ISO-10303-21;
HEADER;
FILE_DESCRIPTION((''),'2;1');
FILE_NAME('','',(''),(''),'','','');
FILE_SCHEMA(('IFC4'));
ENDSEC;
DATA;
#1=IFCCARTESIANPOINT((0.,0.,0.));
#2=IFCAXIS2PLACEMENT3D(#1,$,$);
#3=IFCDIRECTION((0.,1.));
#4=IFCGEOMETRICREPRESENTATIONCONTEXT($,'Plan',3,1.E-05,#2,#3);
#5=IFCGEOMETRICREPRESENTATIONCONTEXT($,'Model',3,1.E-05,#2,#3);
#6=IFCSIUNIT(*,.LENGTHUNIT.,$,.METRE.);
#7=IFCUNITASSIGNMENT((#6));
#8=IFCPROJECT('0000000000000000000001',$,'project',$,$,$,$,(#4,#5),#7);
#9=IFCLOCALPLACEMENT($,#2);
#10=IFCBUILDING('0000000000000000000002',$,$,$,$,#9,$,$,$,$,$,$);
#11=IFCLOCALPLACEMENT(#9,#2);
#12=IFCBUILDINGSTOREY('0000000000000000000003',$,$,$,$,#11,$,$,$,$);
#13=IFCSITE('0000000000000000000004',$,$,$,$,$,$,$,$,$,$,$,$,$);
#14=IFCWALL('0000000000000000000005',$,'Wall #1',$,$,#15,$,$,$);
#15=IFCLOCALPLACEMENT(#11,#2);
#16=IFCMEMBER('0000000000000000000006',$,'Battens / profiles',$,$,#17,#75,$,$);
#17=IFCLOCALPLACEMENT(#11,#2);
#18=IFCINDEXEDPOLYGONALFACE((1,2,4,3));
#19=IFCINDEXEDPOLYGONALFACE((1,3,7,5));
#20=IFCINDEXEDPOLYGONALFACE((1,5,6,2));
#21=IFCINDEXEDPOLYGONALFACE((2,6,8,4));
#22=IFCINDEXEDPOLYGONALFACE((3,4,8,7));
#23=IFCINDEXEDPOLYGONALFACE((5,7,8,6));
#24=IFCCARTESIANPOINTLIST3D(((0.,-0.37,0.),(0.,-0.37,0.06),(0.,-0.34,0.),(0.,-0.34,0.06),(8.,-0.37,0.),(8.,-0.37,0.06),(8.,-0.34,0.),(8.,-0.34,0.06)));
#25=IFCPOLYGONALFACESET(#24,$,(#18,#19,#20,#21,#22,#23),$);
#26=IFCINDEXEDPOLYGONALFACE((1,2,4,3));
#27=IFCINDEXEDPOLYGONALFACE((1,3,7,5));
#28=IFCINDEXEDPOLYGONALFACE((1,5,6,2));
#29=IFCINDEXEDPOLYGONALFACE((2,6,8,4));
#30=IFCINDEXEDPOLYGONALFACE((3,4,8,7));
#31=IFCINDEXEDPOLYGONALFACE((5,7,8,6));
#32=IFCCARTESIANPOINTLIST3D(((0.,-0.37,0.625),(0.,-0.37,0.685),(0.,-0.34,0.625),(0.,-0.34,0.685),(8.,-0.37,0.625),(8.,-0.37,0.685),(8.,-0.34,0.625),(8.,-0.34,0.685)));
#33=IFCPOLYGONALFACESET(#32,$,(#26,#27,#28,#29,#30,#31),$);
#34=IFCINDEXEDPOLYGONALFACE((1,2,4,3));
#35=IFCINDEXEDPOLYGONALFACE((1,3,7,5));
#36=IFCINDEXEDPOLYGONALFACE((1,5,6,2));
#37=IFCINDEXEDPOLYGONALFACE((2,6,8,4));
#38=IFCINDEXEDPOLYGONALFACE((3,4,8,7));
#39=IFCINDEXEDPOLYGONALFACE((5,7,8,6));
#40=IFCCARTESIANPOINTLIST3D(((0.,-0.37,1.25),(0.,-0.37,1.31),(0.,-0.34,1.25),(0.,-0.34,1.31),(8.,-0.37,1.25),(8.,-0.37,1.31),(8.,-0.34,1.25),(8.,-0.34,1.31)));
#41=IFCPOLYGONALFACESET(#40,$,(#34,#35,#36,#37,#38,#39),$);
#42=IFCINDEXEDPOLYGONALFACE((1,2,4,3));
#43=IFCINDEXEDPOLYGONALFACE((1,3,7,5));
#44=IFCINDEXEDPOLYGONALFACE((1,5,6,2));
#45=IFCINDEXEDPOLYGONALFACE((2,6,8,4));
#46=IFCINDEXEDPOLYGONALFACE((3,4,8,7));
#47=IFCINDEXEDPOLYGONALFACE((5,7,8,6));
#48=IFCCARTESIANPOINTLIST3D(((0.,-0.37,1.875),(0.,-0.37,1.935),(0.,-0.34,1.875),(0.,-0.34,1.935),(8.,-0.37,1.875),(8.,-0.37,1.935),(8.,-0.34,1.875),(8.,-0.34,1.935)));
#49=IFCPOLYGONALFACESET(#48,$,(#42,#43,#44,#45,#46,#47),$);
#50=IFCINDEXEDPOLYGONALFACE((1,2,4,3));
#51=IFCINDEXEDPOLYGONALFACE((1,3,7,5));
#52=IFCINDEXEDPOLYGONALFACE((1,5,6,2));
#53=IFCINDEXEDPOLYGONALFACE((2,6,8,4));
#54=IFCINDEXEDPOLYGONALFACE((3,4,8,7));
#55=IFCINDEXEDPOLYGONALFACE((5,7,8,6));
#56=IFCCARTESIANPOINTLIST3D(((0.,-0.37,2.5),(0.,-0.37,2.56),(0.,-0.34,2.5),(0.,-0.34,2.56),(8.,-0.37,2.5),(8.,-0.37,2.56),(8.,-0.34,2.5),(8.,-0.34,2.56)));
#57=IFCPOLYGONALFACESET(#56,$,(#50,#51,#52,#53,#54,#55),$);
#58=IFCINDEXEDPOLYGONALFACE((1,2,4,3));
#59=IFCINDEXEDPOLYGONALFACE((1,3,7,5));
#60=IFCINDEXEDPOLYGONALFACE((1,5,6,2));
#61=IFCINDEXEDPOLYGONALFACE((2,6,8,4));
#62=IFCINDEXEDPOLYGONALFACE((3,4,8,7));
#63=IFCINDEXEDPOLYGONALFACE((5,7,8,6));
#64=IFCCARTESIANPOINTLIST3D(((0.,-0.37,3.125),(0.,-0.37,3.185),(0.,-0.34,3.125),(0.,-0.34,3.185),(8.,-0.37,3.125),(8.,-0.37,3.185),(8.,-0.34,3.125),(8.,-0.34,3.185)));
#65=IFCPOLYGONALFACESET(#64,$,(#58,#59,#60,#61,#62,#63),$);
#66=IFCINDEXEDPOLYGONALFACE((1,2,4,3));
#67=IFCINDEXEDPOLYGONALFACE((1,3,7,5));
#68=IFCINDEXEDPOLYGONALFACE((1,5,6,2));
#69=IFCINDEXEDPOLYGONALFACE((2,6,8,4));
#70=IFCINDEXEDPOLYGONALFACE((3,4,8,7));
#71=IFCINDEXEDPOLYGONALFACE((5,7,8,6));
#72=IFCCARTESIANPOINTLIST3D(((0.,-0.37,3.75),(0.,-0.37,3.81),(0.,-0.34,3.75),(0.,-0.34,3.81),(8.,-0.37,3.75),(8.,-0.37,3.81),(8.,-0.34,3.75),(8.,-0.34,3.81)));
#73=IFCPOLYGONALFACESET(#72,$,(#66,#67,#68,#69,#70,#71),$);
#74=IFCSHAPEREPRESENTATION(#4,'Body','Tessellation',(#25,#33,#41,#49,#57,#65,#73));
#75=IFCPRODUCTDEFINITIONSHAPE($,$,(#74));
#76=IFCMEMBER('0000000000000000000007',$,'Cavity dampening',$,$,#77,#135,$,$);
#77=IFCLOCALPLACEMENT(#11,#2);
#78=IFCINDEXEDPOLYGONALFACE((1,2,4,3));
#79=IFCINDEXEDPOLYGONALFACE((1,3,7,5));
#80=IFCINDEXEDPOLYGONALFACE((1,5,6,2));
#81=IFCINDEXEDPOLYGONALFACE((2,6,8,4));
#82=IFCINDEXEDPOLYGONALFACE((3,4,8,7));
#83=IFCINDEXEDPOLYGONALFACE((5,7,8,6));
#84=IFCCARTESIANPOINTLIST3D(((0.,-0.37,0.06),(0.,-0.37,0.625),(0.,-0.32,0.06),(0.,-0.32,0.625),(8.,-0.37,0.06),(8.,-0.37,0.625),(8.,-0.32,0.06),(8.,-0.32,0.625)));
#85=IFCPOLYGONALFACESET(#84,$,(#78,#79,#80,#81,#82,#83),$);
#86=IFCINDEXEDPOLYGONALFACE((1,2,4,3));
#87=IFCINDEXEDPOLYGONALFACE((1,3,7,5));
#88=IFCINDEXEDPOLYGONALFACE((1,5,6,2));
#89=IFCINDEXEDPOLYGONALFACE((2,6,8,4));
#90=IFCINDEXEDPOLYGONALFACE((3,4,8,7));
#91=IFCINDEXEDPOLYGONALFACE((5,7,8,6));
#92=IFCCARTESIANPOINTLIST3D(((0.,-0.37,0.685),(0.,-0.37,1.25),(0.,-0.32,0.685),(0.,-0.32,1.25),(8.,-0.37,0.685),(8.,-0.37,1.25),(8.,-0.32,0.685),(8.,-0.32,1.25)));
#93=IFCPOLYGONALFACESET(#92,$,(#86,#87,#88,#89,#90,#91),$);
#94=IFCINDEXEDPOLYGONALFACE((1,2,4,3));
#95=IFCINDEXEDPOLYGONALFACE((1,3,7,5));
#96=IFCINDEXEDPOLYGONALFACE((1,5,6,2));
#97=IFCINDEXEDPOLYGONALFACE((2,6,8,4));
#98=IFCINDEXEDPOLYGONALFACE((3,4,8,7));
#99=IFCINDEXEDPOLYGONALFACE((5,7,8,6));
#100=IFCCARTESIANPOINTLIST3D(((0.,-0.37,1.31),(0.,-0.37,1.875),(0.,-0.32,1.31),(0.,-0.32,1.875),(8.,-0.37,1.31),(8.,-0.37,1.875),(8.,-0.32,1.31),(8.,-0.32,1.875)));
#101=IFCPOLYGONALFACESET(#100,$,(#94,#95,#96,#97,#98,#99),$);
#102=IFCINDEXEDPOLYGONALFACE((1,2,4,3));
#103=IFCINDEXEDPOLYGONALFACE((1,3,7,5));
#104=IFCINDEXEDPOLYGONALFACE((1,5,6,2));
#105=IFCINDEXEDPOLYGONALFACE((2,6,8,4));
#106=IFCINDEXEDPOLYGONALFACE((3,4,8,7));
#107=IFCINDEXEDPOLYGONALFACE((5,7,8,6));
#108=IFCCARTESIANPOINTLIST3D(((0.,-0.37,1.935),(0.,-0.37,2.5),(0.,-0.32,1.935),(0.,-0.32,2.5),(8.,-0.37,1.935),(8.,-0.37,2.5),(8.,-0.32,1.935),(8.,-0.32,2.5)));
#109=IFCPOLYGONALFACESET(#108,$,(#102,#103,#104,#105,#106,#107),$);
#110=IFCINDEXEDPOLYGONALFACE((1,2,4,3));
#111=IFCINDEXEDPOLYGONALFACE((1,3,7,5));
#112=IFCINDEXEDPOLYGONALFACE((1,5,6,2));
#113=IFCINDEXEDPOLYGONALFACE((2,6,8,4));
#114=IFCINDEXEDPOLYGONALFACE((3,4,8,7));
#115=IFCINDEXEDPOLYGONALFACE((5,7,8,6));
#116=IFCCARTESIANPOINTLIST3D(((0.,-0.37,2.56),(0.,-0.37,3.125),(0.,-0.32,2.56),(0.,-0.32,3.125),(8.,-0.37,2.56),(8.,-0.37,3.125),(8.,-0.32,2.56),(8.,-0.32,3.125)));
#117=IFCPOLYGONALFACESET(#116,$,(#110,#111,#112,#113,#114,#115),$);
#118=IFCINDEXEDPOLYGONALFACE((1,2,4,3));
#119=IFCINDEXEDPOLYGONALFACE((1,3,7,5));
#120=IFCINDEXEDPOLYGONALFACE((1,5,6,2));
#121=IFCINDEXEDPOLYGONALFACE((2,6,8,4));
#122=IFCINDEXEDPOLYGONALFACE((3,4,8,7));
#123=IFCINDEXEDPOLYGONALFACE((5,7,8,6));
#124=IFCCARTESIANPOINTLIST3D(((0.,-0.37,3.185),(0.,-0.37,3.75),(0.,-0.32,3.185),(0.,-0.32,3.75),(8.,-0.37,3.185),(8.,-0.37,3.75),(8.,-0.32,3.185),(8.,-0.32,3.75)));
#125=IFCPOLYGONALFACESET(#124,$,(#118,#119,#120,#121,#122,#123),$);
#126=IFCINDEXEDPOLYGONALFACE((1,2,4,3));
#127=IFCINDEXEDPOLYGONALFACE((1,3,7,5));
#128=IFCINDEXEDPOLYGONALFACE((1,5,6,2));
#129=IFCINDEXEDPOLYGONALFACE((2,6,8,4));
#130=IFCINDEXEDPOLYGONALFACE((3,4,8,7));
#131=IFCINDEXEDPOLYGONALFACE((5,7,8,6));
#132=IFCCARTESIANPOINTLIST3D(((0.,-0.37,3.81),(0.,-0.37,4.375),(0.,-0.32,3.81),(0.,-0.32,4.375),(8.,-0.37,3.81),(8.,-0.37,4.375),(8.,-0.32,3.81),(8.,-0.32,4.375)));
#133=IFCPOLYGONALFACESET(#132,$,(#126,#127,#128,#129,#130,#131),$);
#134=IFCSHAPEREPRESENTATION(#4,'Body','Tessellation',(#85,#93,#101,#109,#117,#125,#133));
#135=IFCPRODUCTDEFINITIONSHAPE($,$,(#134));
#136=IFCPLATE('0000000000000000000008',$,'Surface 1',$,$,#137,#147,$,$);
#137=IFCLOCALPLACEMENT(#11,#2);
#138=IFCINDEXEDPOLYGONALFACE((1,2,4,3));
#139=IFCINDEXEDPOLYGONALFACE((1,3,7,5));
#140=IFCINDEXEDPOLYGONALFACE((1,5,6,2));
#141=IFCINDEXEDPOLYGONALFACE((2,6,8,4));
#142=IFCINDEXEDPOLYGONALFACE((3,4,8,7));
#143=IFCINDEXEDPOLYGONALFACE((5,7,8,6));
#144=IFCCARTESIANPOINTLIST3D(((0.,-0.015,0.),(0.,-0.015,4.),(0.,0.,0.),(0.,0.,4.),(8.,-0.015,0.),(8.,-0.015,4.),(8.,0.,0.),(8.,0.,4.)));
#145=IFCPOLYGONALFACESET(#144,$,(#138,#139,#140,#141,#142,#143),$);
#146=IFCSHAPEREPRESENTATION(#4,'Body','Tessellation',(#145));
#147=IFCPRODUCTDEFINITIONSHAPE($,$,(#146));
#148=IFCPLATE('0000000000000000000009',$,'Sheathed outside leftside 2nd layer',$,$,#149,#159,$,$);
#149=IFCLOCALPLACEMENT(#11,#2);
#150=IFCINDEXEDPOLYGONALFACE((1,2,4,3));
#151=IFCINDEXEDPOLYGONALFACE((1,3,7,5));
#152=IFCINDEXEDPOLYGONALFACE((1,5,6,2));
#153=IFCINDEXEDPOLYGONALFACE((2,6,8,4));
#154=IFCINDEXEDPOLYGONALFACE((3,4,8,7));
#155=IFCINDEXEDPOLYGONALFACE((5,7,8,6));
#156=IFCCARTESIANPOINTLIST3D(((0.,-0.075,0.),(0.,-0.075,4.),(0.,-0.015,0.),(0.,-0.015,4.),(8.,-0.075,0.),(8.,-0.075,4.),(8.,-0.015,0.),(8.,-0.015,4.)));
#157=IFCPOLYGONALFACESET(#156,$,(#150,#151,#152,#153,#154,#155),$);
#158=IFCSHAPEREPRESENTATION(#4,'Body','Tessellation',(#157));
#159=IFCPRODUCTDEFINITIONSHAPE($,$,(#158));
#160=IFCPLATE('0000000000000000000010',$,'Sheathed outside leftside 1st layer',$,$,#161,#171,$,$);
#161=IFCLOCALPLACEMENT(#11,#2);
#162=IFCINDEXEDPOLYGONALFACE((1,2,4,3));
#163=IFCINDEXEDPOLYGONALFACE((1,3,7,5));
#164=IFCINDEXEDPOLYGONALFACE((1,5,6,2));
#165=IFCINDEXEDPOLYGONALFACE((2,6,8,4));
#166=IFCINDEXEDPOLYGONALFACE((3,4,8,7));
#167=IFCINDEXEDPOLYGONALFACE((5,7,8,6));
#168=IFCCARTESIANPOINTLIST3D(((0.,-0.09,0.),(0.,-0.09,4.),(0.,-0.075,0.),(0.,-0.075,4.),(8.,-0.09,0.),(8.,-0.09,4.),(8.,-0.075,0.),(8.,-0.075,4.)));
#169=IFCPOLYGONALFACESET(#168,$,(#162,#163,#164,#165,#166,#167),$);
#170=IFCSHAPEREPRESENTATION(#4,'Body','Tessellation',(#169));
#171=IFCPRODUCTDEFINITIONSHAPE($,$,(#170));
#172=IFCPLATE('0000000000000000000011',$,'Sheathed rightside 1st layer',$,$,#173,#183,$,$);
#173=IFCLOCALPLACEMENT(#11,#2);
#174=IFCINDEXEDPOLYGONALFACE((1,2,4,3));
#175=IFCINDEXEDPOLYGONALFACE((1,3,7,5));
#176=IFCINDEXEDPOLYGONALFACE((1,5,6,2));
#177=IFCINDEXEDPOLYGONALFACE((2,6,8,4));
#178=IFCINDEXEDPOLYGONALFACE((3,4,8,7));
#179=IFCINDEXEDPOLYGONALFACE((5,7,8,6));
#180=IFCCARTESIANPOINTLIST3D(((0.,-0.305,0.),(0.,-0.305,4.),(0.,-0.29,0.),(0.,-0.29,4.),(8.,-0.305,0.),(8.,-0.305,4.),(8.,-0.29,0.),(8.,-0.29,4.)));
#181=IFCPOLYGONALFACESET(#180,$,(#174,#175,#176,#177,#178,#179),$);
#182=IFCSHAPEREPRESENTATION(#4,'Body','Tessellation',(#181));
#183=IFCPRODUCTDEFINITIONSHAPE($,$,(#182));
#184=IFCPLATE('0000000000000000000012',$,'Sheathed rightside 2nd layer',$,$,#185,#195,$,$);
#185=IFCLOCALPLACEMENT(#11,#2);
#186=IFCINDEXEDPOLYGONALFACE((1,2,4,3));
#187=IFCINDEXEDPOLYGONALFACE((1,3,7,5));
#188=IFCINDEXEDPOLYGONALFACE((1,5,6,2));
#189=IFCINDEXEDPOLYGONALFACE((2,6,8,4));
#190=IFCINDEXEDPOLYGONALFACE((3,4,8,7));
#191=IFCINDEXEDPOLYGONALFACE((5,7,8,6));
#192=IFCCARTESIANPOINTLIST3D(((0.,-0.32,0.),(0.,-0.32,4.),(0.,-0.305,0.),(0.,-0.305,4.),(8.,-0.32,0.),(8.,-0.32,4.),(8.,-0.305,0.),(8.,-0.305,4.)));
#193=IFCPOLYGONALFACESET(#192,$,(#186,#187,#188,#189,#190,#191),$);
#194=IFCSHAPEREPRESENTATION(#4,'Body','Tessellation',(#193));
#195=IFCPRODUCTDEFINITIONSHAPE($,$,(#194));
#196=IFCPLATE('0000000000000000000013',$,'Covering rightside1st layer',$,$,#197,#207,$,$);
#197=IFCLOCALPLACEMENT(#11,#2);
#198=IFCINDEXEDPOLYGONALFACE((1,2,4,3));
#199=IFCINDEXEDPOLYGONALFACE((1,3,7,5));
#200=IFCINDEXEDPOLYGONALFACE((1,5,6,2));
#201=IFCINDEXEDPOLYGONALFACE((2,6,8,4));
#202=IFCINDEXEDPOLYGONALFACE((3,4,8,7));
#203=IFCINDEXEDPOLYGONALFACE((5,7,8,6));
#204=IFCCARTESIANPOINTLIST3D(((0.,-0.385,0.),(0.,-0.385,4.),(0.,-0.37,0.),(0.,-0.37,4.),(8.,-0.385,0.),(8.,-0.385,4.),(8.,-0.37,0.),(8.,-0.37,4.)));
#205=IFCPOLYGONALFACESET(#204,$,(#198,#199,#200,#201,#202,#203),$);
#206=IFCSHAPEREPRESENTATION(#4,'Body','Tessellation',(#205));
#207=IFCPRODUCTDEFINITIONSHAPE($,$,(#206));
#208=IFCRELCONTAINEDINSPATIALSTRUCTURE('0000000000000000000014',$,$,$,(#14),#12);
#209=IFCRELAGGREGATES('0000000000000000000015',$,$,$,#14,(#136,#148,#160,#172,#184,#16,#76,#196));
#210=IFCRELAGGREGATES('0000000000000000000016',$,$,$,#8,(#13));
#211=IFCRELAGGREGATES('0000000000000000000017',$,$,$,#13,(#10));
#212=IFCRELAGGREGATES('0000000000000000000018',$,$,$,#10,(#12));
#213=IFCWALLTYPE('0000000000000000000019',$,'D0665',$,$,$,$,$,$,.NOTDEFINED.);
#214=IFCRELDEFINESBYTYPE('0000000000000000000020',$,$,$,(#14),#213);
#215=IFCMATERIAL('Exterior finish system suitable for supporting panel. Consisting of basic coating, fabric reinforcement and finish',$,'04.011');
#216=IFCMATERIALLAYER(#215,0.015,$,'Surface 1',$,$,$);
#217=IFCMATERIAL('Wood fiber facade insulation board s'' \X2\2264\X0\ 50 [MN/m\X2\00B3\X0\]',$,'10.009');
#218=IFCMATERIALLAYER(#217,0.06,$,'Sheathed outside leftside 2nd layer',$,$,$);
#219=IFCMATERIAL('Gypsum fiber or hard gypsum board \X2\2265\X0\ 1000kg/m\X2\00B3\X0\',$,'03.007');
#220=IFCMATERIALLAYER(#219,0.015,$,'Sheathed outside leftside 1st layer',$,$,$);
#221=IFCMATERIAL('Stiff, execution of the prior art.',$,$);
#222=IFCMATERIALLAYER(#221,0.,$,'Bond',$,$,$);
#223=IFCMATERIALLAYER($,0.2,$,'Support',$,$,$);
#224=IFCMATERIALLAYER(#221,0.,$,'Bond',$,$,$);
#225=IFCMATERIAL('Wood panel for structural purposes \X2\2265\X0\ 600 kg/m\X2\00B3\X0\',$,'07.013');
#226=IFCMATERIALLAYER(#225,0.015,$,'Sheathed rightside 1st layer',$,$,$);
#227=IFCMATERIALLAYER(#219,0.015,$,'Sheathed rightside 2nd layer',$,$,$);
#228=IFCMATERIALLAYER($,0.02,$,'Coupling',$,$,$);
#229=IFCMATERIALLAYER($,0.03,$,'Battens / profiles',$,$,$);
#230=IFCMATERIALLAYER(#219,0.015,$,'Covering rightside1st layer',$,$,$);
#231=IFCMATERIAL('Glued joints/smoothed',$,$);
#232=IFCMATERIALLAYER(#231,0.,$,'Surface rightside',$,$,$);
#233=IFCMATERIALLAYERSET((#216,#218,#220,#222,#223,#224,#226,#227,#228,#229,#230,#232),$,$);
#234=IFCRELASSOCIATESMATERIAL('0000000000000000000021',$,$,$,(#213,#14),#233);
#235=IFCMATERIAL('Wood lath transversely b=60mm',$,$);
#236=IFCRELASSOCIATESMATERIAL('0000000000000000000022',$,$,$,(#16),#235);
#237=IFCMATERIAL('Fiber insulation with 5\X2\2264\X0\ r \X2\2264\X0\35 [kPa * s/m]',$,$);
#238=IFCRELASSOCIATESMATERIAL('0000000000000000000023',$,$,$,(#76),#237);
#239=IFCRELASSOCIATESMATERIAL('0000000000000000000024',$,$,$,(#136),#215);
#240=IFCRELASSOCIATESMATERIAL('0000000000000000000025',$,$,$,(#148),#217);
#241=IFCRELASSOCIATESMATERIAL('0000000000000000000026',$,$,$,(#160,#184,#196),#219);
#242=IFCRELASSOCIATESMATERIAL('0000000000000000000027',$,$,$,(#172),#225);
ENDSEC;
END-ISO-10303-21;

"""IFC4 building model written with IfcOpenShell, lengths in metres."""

from ifc_helpers import new_model, si_unit, direction, frame, frame_2d, origin, origin_with_axes, place, context, project, spatial, rectangle, extrude, material, layer, layer_set, type_object, element, aggregate, save


model = new_model("IFC4")

# Units and contexts
plan_context = context("Plan", 3, precision=1e-05, world=origin(), true_north=direction((0.0, 1.0)))
model_context = context("Model", 3, precision=1e-05, world=origin(), true_north=direction((0.0, 1.0)))
ifc_project = project(units=[si_unit("LENGTHUNIT", "METRE")], contexts=[plan_context, model_context])

# Site, building, storey
site = spatial("IfcSite", under=ifc_project)
building_placement = place(None, origin())
building = spatial("IfcBuilding", under=site, at=building_placement)
storey_placement = place(building_placement, origin())
storey = spatial("IfcBuildingStorey", under=building, at=storey_placement)

# Wall, members, plates
ifc_material_1 = material(Name="Exterior finish system suitable for supporting panel. Consisting of basic coating, fabric reinforcement and finish", Category="04.011")
ifc_layer_1 = layer(ifc_material_1, 0.015, Name="Surface 1")
ifc_material_2 = material(Name="Wood fiber facade insulation board s' ≤ 50 [MN/m³]", Category="10.009")
ifc_layer_2 = layer(ifc_material_2, 0.06, Name="Sheathed outside leftside 2nd layer")
ifc_material_3 = material(Name="Gypsum fiber or hard gypsum board ≥ 1000kg/m³", Category="03.007")
ifc_layer_3 = layer(ifc_material_3, 0.015, Name="Sheathed outside leftside 1st layer")
ifc_material_4 = material(Name="Stiff, execution of the prior art.")
ifc_layer_4 = layer(ifc_material_4, 0.0, Name="Bond")
ifc_layer_5 = layer(None, 0.2, Name="Support")
ifc_layer_6 = layer(ifc_material_4, 0.0, Name="Bond")
ifc_material_5 = material(Name="Wood panel for structural purposes ≥ 600 kg/m³", Category="07.013")
ifc_layer_7 = layer(ifc_material_5, 0.015, Name="Sheathed rightside 1st layer")
ifc_layer_8 = layer(ifc_material_3, 0.015, Name="Sheathed rightside 2nd layer")
ifc_layer_9 = layer(None, 0.02, Name="Coupling")
ifc_layer_10 = layer(None, 0.03, Name="Battens / profiles")
ifc_layer_11 = layer(ifc_material_3, 0.015, Name="Covering rightside1st layer")
ifc_material_6 = material(Name="Glued joints/smoothed")
ifc_layer_12 = layer(ifc_material_6, 0.0, Name="Surface rightside")
ifc_layer_set = layer_set([ifc_layer_1, ifc_layer_2, ifc_layer_3, ifc_layer_4, ifc_layer_5, ifc_layer_6, ifc_layer_7, ifc_layer_8, ifc_layer_9, ifc_layer_10, ifc_layer_11, ifc_layer_12])
wall_type = type_object("IfcWallType", Name="D0665", PredefinedType="NOTDEFINED", material=ifc_layer_set)
wall_placement = place(None, frame((0.0, 0.0, 0.0), z_axis=(0.0, -1.0, 0.0), x_axis=(1.0, 0.0, 0.0)))
wall = element("IfcWall", 1, at=wall_placement, inside=storey, type_object=wall_type, material=ifc_layer_set, Name="Wall #1")
ifc_material_7 = material(Name="Fiber insulation with 5≤ r ≤35 [kPa * s/m]")
ifc_material_8 = material(Name="Wood lath transversely b=60mm")
member_1_placement = place(wall_placement, origin())
member_1 = element("IfcMember", 2, at=member_1_placement, material=ifc_material_8, Name="Battens / profiles", context=plan_context, shape_type="SweptSolid", body=[
    extrude(rectangle(XDim=0.06, YDim=0.03, at=frame_2d((0.03, 0.015), x_axis=(1.0, 0.0))), frame((0.0, 0.0, 0.34), z_axis=(1.0, 0.0, 0.0), x_axis=(0.0, 1.0, 0.0)), (0.0, 0.0, 1.0), 8.0),
    extrude(rectangle(XDim=0.06, YDim=0.03, at=frame_2d((0.03, 0.015), x_axis=(1.0, 0.0))), frame((0.0, 0.625, 0.34), z_axis=(1.0, 0.0, 0.0), x_axis=(0.0, 1.0, 0.0)), (0.0, 0.0, 1.0), 8.0),
    extrude(rectangle(XDim=0.06, YDim=0.03, at=frame_2d((0.03, 0.015), x_axis=(1.0, 0.0))), frame((0.0, 1.25, 0.34), z_axis=(1.0, 0.0, 0.0), x_axis=(0.0, 1.0, 0.0)), (0.0, 0.0, 1.0), 8.0),
    extrude(rectangle(XDim=0.06, YDim=0.03, at=frame_2d((0.03, 0.015), x_axis=(1.0, 0.0))), frame((0.0, 1.875, 0.34), z_axis=(1.0, 0.0, 0.0), x_axis=(0.0, 1.0, 0.0)), (0.0, 0.0, 1.0), 8.0),
    extrude(rectangle(XDim=0.06, YDim=0.03, at=frame_2d((0.03, 0.015), x_axis=(1.0, 0.0))), frame((0.0, 2.5, 0.34), z_axis=(1.0, 0.0, 0.0), x_axis=(0.0, 1.0, 0.0)), (0.0, 0.0, 1.0), 8.0),
    extrude(rectangle(XDim=0.06, YDim=0.03, at=frame_2d((0.03, 0.015), x_axis=(1.0, 0.0))), frame((0.0, 3.125, 0.34), z_axis=(1.0, 0.0, 0.0), x_axis=(0.0, 1.0, 0.0)), (0.0, 0.0, 1.0), 8.0),
    extrude(rectangle(XDim=0.06, YDim=0.03, at=frame_2d((0.03, 0.015), x_axis=(1.0, 0.0))), frame((0.0, 3.75, 0.34), z_axis=(1.0, 0.0, 0.0), x_axis=(0.0, 1.0, 0.0)), (0.0, 0.0, 1.0), 8.0),
])
member_2_placement = place(wall_placement, origin())
member_2 = element("IfcMember", 3, at=member_2_placement, material=ifc_material_7, Name="Cavity dampening", context=plan_context, shape_type="SweptSolid", body=[
    extrude(rectangle(XDim=0.565, YDim=0.05, at=frame_2d((0.2825, 0.025), x_axis=(1.0, 0.0))), frame((0.0, 0.06, 0.32), z_axis=(1.0, 0.0, 0.0), x_axis=(0.0, 1.0, 0.0)), (0.0, 0.0, 1.0), 8.0),
    extrude(rectangle(XDim=0.565, YDim=0.05, at=frame_2d((0.2825, 0.025), x_axis=(1.0, 0.0))), frame((0.0, 0.685, 0.32), z_axis=(1.0, 0.0, 0.0), x_axis=(0.0, 1.0, 0.0)), (0.0, 0.0, 1.0), 8.0),
    extrude(rectangle(XDim=0.565, YDim=0.05, at=frame_2d((0.2825, 0.025), x_axis=(1.0, 0.0))), frame((0.0, 1.31, 0.32), z_axis=(1.0, 0.0, 0.0), x_axis=(0.0, 1.0, 0.0)), (0.0, 0.0, 1.0), 8.0),
    extrude(rectangle(XDim=0.565, YDim=0.05, at=frame_2d((0.2825, 0.025), x_axis=(1.0, 0.0))), frame((0.0, 1.935, 0.32), z_axis=(1.0, 0.0, 0.0), x_axis=(0.0, 1.0, 0.0)), (0.0, 0.0, 1.0), 8.0),
    extrude(rectangle(XDim=0.565, YDim=0.05, at=frame_2d((0.2825, 0.025), x_axis=(1.0, 0.0))), frame((0.0, 2.56, 0.32), z_axis=(1.0, 0.0, 0.0), x_axis=(0.0, 1.0, 0.0)), (0.0, 0.0, 1.0), 8.0),
    extrude(rectangle(XDim=0.565, YDim=0.05, at=frame_2d((0.2825, 0.025), x_axis=(1.0, 0.0))), frame((0.0, 3.185, 0.32), z_axis=(1.0, 0.0, 0.0), x_axis=(0.0, 1.0, 0.0)), (0.0, 0.0, 1.0), 8.0),
    extrude(rectangle(XDim=0.565, YDim=0.05, at=frame_2d((0.2825, 0.025), x_axis=(1.0, 0.0))), frame((0.0, 3.81, 0.32), z_axis=(1.0, 0.0, 0.0), x_axis=(0.0, 1.0, 0.0)), (0.0, 0.0, 1.0), 8.0),
])
plate_1_placement = place(wall_placement, origin())
plate_1 = element("IfcPlate", 4, at=plate_1_placement, material=ifc_material_1, Name="Surface 1", context=plan_context, shape_type="SweptSolid", body=[
    extrude(rectangle(XDim=8.0, YDim=4.0, at=frame_2d((4.0, 2.0), x_axis=(1.0, 0.0))), origin_with_axes(), (0.0, 0.0, 1.0), 0.015),
])
plate_2_placement = place(wall_placement, origin())
plate_2 = element("IfcPlate", 5, at=plate_2_placement, material=ifc_material_2, Name="Sheathed outside leftside 2nd layer", context=plan_context, shape_type="SweptSolid", body=[
    extrude(rectangle(XDim=8.0, YDim=4.0, at=frame_2d((4.0, 2.0), x_axis=(1.0, 0.0))), frame((0.0, 0.0, 0.015), z_axis=(0.0, 0.0, 1.0), x_axis=(1.0, 0.0, 0.0)), (0.0, 0.0, 1.0), 0.06),
])
plate_3_placement = place(wall_placement, origin())
plate_3 = element("IfcPlate", 6, at=plate_3_placement, material=ifc_material_3, Name="Sheathed outside leftside 1st layer", context=plan_context, shape_type="SweptSolid", body=[
    extrude(rectangle(XDim=8.0, YDim=4.0, at=frame_2d((4.0, 2.0), x_axis=(1.0, 0.0))), frame((0.0, 0.0, 0.075), z_axis=(0.0, 0.0, 1.0), x_axis=(1.0, 0.0, 0.0)), (0.0, 0.0, 1.0), 0.015),
])
plate_4_placement = place(wall_placement, origin())
plate_4 = element("IfcPlate", 7, at=plate_4_placement, material=ifc_material_5, Name="Sheathed rightside 1st layer", context=plan_context, shape_type="SweptSolid", body=[
    extrude(rectangle(XDim=8.0, YDim=4.0, at=frame_2d((4.0, 2.0), x_axis=(1.0, 0.0))), frame((0.0, 0.0, 0.29), z_axis=(0.0, 0.0, 1.0), x_axis=(1.0, 0.0, 0.0)), (0.0, 0.0, 1.0), 0.015),
])
plate_5_placement = place(wall_placement, origin())
plate_5 = element("IfcPlate", 8, at=plate_5_placement, material=ifc_material_3, Name="Sheathed rightside 2nd layer", context=plan_context, shape_type="SweptSolid", body=[
    extrude(rectangle(XDim=8.0, YDim=4.0, at=frame_2d((4.0, 2.0), x_axis=(1.0, 0.0))), frame((0.0, 0.0, 0.305), z_axis=(0.0, 0.0, 1.0), x_axis=(1.0, 0.0, 0.0)), (0.0, 0.0, 1.0), 0.015),
])
plate_6_placement = place(wall_placement, origin())
plate_6 = element("IfcPlate", 9, at=plate_6_placement, material=ifc_material_3, Name="Covering rightside1st layer", context=plan_context, shape_type="SweptSolid", body=[
    extrude(rectangle(XDim=8.0, YDim=4.0, at=frame_2d((4.0, 2.0), x_axis=(1.0, 0.0))), frame((0.0, 0.0, 0.37), z_axis=(0.0, 0.0, 1.0), x_axis=(1.0, 0.0, 0.0)), (0.0, 0.0, 1.0), 0.015),
])
aggregate(wall, [plate_1, plate_2, plate_3, plate_4, plate_5, member_1, member_2, plate_6])

save(model, "model.ifc")
